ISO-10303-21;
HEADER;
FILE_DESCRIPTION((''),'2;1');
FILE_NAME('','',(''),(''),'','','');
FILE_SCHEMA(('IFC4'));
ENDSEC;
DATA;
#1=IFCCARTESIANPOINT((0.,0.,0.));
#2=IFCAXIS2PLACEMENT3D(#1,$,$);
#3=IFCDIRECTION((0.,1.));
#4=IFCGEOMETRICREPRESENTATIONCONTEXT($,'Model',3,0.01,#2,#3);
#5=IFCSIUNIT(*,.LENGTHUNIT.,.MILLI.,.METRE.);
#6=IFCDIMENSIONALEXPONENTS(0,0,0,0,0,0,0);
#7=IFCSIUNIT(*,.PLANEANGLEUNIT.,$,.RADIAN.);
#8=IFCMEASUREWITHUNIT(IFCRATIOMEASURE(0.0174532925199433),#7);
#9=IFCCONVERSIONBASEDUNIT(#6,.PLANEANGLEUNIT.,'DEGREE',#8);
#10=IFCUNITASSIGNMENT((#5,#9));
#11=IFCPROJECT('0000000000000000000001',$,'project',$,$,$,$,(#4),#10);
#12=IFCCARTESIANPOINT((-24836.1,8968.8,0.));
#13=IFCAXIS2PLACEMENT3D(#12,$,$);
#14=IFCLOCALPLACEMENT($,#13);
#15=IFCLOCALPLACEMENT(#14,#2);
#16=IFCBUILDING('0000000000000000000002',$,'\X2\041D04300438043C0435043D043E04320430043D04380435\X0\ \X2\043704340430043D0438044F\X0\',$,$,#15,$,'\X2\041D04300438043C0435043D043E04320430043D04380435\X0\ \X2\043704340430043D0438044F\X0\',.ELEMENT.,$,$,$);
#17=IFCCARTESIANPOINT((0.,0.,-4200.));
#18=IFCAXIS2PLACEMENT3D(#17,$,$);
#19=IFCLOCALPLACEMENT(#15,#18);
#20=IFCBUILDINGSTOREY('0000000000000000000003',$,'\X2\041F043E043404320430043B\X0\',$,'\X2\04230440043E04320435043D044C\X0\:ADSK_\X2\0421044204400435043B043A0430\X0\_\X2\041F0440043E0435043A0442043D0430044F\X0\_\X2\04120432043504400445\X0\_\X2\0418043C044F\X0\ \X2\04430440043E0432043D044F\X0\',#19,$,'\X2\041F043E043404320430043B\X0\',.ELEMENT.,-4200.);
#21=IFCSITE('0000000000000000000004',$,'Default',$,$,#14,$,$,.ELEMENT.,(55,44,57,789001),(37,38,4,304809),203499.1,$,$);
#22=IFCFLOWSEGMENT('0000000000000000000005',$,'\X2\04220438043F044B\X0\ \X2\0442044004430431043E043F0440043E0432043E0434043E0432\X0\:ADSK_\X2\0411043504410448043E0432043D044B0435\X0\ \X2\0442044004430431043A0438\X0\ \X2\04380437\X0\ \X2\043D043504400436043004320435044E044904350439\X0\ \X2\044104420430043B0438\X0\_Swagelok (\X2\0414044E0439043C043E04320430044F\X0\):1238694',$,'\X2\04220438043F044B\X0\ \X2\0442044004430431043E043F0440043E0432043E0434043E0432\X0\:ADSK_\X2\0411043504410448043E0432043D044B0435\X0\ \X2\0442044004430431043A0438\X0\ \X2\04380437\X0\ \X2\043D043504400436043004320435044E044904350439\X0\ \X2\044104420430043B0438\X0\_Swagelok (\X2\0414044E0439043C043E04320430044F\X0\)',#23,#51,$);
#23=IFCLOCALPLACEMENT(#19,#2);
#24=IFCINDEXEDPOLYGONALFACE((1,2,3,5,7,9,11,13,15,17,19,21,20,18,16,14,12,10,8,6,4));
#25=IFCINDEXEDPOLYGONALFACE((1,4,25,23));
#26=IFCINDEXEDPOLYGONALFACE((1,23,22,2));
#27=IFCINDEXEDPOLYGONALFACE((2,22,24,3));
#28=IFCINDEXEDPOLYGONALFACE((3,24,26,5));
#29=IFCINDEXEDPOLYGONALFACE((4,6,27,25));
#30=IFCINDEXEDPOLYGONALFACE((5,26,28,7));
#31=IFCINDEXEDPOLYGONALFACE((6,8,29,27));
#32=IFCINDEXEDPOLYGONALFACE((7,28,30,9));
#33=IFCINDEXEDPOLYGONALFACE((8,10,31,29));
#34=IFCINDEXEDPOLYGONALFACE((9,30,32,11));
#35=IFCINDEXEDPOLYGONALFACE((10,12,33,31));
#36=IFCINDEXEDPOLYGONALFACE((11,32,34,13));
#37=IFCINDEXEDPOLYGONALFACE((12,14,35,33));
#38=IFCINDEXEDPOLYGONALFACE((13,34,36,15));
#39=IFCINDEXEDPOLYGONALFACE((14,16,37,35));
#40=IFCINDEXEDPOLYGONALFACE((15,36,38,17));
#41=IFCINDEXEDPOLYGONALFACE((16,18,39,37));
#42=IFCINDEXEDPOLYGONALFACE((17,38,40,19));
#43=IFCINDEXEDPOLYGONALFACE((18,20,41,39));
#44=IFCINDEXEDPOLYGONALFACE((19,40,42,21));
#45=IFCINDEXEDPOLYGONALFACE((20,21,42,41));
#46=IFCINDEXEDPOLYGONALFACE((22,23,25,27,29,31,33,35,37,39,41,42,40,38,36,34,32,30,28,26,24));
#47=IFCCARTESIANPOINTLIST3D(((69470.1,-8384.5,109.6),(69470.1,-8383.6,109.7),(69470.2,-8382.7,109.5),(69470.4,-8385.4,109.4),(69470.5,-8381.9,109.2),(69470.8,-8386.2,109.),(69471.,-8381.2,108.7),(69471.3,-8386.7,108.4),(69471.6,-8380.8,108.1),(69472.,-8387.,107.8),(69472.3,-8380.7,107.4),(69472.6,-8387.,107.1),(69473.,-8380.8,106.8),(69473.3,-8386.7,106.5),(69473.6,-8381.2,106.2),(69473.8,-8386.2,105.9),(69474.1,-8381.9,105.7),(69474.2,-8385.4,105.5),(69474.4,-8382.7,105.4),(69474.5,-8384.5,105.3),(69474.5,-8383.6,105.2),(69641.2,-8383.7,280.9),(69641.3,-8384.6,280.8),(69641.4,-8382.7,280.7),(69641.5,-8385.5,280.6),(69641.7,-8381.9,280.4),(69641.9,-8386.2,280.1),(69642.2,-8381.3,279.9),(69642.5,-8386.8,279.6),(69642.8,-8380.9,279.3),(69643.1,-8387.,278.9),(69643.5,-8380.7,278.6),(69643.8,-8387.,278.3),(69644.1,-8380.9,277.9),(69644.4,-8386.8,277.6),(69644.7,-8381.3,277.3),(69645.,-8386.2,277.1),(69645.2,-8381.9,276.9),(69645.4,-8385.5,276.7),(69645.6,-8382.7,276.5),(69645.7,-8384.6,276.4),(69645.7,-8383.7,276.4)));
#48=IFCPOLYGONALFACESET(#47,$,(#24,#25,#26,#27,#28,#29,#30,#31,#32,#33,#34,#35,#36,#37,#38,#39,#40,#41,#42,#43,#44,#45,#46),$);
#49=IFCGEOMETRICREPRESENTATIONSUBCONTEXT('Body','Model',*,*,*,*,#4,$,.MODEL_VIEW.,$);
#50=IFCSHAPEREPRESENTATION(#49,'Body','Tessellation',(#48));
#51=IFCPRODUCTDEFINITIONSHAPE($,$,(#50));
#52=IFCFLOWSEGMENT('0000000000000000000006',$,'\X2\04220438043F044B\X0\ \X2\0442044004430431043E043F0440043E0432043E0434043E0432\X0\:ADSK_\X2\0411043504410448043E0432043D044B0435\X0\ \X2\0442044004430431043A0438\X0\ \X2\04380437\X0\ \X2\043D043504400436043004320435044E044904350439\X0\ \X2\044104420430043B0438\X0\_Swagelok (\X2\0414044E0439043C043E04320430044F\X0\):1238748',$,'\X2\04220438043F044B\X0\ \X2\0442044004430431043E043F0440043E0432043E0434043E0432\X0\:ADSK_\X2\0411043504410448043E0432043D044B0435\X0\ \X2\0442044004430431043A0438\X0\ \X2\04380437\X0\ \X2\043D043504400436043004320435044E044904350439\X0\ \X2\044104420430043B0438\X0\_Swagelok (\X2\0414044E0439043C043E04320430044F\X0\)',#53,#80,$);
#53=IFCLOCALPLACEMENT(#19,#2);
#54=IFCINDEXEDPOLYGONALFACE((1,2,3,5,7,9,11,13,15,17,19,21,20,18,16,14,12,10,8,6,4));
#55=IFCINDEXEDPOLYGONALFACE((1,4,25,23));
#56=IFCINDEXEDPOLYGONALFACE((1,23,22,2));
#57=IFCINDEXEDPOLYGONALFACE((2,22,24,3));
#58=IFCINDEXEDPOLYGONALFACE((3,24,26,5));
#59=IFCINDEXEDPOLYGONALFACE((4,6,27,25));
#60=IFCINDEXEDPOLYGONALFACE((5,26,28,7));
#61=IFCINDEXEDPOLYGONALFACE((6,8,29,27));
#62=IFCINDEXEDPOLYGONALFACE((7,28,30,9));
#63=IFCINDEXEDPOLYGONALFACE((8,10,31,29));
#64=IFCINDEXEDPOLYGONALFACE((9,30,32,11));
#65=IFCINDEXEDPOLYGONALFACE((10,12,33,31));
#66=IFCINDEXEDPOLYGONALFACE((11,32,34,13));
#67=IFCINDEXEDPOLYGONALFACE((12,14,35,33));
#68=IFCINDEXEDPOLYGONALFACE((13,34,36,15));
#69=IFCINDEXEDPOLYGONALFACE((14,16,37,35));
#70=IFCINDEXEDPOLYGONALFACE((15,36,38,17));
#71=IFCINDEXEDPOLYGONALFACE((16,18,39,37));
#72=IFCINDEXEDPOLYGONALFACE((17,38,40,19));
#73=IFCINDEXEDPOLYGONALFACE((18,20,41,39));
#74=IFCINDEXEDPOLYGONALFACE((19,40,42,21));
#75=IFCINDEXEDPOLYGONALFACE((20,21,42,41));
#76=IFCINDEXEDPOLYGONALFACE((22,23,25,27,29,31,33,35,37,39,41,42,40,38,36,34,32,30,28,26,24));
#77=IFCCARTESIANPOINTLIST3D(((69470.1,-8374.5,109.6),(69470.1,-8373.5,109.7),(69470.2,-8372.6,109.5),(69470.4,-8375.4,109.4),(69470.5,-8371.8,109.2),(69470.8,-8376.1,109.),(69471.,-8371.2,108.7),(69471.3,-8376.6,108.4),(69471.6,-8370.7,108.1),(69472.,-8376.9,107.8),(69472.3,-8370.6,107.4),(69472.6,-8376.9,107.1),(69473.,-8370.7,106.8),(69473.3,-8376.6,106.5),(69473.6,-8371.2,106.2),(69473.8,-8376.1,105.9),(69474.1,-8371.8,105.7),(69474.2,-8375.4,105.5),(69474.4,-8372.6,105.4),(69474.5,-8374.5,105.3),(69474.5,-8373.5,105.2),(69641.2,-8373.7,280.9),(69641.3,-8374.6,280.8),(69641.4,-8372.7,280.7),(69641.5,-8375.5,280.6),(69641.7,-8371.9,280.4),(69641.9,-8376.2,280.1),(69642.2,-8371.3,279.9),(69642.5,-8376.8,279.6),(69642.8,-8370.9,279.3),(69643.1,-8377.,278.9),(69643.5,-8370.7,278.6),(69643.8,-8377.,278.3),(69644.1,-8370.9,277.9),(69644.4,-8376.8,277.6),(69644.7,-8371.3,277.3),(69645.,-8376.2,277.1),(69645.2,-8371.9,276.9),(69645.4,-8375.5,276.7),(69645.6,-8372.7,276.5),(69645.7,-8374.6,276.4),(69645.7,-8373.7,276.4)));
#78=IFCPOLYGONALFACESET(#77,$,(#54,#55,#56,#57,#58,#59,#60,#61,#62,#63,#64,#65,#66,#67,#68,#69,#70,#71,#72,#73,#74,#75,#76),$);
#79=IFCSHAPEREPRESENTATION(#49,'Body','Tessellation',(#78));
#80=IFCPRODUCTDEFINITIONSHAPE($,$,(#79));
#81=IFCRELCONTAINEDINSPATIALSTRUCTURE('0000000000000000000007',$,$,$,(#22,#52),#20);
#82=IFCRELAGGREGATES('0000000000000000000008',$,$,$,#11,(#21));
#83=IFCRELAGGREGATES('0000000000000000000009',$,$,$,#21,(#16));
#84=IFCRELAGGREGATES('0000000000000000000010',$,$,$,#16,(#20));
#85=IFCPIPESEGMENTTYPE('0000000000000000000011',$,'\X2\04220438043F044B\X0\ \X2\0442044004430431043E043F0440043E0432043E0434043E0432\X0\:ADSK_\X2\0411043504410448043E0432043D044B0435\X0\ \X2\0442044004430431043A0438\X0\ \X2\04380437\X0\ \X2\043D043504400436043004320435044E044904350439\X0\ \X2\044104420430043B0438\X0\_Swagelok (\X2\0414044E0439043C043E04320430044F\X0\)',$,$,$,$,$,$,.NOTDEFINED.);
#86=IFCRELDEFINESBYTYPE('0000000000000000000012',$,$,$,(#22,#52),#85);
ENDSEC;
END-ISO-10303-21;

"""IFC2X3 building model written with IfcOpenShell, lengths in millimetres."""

from ifc_helpers import new_model, entity, si_unit, converted_unit, direction, frame, origin, origin_2d_with_axis, place, context, subcontext, project, spatial, circle, extrude, type_object, element, save


model = new_model("IFC2X3")

# Units and contexts
model_context = context("Model", 3, precision=0.01, world=origin(), true_north=direction((0.0, 1.0)))
body_context = subcontext(model_context, "Body", "Model", "MODEL_VIEW")
ifc_project = project(units=[si_unit("LENGTHUNIT", "METRE", prefix="MILLI"), converted_unit("PLANEANGLEUNIT", "DEGREE", entity("IfcRatioMeasure", 0.0174532925199433), si_unit("PLANEANGLEUNIT", "RADIAN"), dimensions=[0, 0, 0, 0, 0, 0, 0])], contexts=[model_context])

# Site, building, storey
site_placement = place(None, frame((-24836.1, 8968.8, 0.0)))
site = spatial("IfcSite", under=ifc_project, at=site_placement, Name="Default", CompositionType="ELEMENT", RefLatitude=(55, 44, 57, 789001), RefLongitude=(37, 38, 4, 304809), RefElevation=203499.1)
building_placement = place(site_placement, origin())
building = spatial("IfcBuilding", under=site, at=building_placement, Name="Наименование здания", LongName="Наименование здания", CompositionType="ELEMENT")
storey_placement = place(building_placement, frame((0.0, 0.0, -4200.0)))
storey = spatial("IfcBuildingStorey", under=building, at=storey_placement, Name="Подвал", ObjectType="Уровень:ADSK_Стрелка_Проектная_Вверх_Имя уровня", LongName="Подвал", CompositionType="ELEMENT", Elevation=-4200.0)

# Flow segments
pipe_segment_type = type_object("IfcPipeSegmentType", Name="Типы трубопроводов:ADSK_Бесшовные трубки из нержавеющей стали_Swagelok (Дюймовая)", PredefinedType="NOTDEFINED")
flow_segment_1_placement = place(storey_placement, frame((69468.5, -8388.7, 103.6)))
element("IfcFlowSegment", 1, at=flow_segment_1_placement, inside=storey, type_object=pipe_segment_type, Name="Типы трубопроводов:ADSK_Бесшовные трубки из нержавеющей стали_Swagelok (Дюймовая):1238694", ObjectType="Типы трубопроводов:ADSK_Бесшовные трубки из нержавеющей стали_Swagelok (Дюймовая)", context=body_context, shape_type="SweptSolid", body=[
    extrude(circle(Radius=3.2, at=origin_2d_with_axis()), frame((3.8, 4.8, 3.8), z_axis=(0.707107, -0.00025, 0.707107), x_axis=(0.000353, 1.0, 0.0)), (0.0, 0.0, 1.0), 242.1),
])
flow_segment_2_placement = place(storey_placement, frame((69468.5, -8378.7, 103.6)))
element("IfcFlowSegment", 2, at=flow_segment_2_placement, inside=storey, type_object=pipe_segment_type, Name="Типы трубопроводов:ADSK_Бесшовные трубки из нержавеющей стали_Swagelok (Дюймовая):1238748", ObjectType="Типы трубопроводов:ADSK_Бесшовные трубки из нержавеющей стали_Swagelok (Дюймовая)", context=body_context, shape_type="SweptSolid", body=[
    extrude(circle(Radius=3.2, at=origin_2d_with_axis()), frame((3.8, 4.9, 3.8), z_axis=(0.707107, -0.000499, 0.707107), x_axis=(0.000706, 1.0, 0.0)), (0.0, 0.0, 1.0), 242.1),
])

save(model, "model.ifc")
